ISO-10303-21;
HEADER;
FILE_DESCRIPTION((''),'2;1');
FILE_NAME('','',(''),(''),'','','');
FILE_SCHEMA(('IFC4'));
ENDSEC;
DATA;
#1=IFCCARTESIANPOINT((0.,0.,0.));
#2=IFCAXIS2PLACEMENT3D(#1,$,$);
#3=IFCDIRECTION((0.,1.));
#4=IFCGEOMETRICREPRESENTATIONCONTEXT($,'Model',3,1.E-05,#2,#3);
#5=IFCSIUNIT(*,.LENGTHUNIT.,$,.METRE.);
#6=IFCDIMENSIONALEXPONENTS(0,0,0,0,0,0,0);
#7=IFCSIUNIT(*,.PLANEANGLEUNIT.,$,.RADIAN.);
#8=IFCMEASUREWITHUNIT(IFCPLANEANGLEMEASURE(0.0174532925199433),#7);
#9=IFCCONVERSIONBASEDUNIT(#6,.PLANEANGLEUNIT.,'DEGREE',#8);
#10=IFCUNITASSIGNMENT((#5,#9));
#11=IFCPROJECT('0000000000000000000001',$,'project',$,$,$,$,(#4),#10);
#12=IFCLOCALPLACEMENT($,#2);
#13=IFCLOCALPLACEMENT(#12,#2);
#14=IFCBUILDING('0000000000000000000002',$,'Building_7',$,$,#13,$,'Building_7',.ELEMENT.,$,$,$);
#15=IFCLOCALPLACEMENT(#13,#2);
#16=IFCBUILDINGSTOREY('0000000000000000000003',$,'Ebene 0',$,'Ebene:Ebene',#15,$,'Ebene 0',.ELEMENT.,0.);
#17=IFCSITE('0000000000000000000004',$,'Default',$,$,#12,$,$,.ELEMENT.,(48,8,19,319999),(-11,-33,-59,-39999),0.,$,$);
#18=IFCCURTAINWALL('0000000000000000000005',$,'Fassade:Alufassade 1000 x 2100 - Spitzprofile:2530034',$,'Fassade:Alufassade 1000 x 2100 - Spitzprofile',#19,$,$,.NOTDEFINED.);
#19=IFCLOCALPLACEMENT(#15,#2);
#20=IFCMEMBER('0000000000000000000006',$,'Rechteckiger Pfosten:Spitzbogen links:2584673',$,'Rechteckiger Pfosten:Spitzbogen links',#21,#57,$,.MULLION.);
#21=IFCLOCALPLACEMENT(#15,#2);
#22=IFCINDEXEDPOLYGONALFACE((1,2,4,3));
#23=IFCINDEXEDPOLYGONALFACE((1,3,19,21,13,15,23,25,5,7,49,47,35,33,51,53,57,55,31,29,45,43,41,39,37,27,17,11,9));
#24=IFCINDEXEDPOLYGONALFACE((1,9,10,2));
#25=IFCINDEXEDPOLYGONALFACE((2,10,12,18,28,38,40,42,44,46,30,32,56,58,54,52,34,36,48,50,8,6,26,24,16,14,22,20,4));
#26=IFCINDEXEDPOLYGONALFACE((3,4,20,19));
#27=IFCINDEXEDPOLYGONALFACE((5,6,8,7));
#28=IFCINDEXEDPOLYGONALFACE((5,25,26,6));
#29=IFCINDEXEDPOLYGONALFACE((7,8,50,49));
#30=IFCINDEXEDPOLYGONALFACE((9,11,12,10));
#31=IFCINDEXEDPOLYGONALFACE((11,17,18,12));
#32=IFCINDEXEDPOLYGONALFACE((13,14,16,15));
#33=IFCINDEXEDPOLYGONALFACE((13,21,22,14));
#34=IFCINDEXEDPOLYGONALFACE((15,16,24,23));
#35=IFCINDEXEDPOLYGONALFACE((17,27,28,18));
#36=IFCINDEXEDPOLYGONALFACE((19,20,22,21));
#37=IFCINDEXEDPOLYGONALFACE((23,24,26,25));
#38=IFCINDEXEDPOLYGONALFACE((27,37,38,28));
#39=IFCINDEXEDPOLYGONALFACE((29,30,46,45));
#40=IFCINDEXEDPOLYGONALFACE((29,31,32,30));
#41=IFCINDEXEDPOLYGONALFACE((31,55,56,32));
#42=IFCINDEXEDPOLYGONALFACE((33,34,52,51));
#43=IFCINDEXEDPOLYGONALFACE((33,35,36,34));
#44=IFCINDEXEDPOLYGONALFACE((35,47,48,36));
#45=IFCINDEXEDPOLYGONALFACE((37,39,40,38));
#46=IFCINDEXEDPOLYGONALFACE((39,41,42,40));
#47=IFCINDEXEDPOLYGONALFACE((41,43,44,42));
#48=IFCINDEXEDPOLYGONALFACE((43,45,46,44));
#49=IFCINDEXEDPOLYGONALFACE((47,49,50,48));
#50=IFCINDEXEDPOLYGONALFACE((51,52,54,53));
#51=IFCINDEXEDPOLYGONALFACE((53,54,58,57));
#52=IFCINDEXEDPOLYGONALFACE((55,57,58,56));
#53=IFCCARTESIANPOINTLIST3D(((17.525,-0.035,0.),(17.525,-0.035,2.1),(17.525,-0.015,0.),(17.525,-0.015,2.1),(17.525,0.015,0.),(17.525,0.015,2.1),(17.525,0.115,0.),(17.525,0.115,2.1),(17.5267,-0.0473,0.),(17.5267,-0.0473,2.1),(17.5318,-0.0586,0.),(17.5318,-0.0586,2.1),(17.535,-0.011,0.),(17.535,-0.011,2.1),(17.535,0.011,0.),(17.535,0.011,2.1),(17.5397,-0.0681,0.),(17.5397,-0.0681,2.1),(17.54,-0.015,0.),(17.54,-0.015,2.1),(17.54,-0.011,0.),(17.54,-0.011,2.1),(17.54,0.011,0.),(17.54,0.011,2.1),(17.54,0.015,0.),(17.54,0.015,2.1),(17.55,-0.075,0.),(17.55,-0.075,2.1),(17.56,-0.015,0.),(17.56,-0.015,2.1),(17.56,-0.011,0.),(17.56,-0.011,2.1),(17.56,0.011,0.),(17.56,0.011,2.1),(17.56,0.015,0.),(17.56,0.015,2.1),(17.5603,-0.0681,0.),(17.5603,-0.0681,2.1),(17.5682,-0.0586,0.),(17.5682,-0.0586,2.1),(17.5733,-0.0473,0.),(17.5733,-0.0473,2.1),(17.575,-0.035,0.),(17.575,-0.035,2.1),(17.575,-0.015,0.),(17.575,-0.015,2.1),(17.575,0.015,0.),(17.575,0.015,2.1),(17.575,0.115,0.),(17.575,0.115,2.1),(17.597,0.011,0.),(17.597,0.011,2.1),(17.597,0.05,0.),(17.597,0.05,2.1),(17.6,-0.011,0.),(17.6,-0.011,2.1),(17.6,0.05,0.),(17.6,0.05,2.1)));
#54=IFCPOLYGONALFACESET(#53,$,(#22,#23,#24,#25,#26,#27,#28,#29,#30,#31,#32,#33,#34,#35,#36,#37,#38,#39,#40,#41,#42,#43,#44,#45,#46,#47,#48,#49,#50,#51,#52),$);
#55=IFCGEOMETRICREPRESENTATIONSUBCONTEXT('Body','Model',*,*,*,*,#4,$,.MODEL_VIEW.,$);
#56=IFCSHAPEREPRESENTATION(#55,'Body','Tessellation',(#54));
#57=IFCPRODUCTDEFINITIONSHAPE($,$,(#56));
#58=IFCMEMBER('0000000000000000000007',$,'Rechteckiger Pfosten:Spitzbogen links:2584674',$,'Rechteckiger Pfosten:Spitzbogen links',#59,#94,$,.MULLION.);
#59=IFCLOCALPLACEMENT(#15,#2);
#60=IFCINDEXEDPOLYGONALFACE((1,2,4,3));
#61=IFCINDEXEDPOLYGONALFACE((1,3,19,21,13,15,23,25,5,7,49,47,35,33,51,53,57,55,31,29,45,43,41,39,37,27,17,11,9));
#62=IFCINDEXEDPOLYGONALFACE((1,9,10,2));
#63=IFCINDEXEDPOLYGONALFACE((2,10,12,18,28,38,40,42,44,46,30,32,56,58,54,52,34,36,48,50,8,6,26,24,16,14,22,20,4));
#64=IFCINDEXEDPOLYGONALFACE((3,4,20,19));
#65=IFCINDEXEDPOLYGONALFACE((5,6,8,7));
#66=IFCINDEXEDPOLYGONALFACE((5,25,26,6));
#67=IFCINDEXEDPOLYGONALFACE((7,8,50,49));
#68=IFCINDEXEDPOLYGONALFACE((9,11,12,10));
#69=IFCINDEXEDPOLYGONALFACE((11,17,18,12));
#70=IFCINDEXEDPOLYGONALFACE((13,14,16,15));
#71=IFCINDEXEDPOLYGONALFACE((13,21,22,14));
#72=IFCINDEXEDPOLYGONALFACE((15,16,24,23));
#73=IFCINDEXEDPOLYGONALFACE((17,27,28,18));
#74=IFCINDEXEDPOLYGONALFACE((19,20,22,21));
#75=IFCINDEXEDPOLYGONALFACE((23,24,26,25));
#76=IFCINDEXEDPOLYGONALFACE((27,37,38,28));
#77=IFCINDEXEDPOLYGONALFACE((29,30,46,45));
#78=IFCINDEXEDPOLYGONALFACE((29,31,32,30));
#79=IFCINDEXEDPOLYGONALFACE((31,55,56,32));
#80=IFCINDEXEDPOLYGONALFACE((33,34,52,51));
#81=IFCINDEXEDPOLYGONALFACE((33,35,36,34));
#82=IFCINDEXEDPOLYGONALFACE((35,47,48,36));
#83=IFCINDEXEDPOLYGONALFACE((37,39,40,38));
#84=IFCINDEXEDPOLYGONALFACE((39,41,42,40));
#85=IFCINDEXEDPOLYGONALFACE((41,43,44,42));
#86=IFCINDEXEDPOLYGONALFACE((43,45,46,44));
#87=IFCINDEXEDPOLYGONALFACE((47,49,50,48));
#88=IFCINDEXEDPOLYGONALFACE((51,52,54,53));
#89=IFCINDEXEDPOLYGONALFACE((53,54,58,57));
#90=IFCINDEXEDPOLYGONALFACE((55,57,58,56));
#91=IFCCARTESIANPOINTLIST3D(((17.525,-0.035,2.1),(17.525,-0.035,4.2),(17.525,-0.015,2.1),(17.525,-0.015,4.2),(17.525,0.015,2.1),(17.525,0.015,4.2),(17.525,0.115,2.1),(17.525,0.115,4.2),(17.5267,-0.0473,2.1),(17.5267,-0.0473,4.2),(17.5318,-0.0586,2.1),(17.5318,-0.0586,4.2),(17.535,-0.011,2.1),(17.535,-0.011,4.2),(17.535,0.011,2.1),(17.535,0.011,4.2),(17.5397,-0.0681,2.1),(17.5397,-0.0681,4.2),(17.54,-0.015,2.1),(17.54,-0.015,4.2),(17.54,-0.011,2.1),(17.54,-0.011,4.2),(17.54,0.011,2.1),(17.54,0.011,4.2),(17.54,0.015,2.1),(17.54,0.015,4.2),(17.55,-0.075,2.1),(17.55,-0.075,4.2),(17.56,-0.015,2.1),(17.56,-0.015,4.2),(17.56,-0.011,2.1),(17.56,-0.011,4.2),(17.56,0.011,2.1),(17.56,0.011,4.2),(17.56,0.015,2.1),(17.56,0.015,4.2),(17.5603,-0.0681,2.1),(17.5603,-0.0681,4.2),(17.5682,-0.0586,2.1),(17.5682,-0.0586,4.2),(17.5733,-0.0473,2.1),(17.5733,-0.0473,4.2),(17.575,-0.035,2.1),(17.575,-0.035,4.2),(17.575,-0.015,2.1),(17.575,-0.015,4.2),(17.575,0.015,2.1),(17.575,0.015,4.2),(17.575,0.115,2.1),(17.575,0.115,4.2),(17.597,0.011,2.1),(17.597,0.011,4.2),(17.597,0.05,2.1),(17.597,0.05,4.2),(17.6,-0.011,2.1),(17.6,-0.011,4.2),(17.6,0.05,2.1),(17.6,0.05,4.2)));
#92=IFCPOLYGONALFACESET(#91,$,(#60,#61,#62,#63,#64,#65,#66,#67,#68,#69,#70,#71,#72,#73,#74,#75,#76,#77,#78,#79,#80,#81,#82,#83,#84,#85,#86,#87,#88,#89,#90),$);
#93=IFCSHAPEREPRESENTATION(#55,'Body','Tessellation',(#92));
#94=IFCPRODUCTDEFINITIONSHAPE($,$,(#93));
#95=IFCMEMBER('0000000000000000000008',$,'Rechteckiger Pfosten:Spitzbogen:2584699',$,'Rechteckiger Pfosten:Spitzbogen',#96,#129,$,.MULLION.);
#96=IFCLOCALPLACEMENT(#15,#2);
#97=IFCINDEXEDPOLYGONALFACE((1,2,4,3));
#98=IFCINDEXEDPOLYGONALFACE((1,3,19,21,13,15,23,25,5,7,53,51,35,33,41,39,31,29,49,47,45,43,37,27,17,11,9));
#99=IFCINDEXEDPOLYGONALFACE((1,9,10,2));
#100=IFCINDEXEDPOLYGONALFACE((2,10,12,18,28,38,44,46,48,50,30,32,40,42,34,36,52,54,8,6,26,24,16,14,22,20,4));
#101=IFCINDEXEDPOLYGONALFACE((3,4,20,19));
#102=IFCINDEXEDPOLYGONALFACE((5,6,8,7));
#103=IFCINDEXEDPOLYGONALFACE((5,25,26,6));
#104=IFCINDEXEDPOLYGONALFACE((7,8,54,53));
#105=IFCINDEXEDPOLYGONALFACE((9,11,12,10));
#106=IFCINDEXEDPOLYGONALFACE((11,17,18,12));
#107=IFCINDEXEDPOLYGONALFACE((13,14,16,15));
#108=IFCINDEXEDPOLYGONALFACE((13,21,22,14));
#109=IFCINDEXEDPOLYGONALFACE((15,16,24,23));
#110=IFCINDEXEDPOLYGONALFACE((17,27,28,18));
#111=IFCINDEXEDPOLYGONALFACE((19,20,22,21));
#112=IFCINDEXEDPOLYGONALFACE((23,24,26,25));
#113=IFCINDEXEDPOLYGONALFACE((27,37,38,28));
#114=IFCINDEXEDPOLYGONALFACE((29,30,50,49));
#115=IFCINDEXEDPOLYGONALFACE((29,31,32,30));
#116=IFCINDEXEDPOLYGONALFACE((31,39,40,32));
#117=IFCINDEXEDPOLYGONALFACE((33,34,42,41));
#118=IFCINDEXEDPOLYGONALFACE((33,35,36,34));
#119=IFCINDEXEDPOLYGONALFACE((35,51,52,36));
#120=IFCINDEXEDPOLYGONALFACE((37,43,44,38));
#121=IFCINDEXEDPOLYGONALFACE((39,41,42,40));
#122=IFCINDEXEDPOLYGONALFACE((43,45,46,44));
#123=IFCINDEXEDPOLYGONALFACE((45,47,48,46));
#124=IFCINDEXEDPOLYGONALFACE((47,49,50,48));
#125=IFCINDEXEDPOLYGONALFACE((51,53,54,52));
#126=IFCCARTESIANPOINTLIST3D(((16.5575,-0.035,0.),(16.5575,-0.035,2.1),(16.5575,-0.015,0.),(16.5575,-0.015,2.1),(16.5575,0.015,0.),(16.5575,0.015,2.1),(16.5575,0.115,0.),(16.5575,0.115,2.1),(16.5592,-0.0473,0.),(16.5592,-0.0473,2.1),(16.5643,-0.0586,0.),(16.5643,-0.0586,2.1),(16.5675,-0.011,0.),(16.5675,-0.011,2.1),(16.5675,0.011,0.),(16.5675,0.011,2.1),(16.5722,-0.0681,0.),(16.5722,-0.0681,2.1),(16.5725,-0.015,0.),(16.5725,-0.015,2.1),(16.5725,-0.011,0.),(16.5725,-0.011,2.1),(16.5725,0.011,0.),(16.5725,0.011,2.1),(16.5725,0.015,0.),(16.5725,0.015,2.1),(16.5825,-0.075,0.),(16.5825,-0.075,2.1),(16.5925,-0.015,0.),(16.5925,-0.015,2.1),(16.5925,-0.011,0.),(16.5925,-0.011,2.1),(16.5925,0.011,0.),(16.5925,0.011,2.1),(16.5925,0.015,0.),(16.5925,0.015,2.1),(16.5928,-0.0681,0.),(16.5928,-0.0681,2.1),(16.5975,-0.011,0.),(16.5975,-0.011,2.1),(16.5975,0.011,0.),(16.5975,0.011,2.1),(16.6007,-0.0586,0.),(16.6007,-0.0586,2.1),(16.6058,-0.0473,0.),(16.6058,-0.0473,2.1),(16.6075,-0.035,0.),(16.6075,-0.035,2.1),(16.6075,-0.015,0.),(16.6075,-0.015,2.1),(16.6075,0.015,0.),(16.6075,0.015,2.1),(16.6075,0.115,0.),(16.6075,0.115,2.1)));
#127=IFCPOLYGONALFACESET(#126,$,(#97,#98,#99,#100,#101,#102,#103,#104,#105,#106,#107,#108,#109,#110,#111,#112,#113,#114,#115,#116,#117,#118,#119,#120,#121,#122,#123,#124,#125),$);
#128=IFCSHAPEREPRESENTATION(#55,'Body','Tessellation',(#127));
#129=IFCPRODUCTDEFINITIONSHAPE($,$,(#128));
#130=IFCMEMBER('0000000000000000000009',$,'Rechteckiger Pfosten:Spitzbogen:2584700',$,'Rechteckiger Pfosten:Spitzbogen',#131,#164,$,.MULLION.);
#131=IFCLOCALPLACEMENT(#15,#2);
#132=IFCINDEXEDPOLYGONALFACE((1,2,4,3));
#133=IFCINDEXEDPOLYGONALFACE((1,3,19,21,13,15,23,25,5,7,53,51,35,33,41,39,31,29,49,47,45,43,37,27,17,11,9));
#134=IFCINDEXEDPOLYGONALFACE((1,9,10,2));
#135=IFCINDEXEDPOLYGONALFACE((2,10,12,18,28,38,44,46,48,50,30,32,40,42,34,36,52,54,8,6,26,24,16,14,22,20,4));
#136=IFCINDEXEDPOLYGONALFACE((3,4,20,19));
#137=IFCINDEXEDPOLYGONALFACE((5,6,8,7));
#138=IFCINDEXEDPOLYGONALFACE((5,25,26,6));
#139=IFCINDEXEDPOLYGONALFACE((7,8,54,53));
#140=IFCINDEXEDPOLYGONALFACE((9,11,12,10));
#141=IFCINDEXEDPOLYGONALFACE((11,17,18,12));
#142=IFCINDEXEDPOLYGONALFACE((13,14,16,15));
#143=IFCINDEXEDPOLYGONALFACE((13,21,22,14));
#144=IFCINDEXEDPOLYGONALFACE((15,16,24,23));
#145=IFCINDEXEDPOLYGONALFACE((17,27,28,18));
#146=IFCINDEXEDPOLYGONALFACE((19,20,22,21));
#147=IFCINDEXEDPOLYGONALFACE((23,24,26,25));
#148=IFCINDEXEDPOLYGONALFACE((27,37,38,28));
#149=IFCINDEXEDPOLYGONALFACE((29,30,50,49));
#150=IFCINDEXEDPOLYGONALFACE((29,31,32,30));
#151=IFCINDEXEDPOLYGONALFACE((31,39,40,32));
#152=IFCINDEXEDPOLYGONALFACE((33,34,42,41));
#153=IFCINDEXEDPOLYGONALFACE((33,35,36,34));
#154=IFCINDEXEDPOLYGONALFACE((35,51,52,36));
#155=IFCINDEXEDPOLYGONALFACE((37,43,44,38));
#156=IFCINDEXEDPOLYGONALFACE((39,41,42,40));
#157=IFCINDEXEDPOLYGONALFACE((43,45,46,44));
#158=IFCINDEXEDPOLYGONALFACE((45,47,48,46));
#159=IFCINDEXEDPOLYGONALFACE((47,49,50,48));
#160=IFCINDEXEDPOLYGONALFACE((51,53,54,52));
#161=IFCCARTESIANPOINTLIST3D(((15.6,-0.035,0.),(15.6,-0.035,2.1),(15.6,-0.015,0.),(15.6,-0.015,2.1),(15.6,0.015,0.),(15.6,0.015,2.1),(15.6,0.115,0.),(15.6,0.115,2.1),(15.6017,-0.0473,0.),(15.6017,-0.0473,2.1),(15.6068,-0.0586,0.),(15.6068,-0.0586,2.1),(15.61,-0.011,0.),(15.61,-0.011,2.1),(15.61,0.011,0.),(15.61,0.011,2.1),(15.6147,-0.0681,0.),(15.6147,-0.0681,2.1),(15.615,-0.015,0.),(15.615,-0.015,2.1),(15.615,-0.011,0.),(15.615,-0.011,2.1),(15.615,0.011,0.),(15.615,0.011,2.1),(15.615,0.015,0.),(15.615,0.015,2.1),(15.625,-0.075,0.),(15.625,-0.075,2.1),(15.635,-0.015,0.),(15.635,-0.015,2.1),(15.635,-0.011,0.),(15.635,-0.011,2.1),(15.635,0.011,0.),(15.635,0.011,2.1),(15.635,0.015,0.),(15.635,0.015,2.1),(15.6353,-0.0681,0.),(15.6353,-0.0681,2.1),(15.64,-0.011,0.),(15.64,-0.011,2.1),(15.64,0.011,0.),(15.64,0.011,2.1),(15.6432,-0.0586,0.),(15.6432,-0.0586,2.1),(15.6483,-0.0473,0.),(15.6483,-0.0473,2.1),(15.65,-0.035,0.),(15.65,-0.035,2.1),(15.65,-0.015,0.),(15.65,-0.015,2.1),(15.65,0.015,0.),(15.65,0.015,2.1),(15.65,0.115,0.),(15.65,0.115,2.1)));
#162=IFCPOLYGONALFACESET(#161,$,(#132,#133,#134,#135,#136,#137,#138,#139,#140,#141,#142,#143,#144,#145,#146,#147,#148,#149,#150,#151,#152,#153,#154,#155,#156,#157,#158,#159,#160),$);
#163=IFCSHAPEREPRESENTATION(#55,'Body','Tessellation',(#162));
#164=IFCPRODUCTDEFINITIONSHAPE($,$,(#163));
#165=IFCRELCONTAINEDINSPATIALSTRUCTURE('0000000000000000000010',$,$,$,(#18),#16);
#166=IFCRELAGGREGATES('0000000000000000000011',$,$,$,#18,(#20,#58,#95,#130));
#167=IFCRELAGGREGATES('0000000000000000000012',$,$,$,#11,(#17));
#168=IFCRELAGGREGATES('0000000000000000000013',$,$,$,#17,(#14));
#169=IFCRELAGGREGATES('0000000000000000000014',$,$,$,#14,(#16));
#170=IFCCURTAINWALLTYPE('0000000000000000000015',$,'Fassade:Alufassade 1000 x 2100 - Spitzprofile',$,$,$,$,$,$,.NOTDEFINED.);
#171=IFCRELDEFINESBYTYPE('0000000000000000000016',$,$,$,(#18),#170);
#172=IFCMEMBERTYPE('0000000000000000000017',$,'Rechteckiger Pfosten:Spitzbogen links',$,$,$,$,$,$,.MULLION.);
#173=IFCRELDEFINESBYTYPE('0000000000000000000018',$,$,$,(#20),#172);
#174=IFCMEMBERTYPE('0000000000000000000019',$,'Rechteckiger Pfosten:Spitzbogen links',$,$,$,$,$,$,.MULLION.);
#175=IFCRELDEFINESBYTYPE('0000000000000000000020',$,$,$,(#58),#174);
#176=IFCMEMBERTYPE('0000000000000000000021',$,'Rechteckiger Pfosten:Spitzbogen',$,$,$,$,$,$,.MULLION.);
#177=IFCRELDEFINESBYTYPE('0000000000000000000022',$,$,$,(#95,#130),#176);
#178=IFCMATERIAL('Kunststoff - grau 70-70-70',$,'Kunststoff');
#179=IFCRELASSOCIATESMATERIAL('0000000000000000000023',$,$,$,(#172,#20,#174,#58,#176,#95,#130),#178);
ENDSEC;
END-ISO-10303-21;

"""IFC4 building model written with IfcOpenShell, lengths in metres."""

from ifc_helpers import new_model, entity, si_unit, converted_unit, direction, frame, origin, place, context, subcontext, project, spatial, line, arc, indexed_curve, outline, extrude, source, transform, mapped, material, type_object, type_shapes, element, aggregate, save


model = new_model("IFC4")

# Units and contexts
model_context = context("Model", 3, precision=1e-05, world=origin(), true_north=direction((0.0, 1.0)))
body_context = subcontext(model_context, "Body", "Model", "MODEL_VIEW")
ifc_project = project(units=[si_unit("LENGTHUNIT", "METRE"), converted_unit("PLANEANGLEUNIT", "DEGREE", entity("IfcPlaneAngleMeasure", 0.0174532925199433), si_unit("PLANEANGLEUNIT", "RADIAN"), dimensions=[0, 0, 0, 0, 0, 0, 0])], contexts=[model_context])

# Site, building, storey
site_placement = place(None, origin())
site = spatial("IfcSite", under=ifc_project, at=site_placement, Name="Default", CompositionType="ELEMENT", RefLatitude=(48, 8, 19, 319999), RefLongitude=(-11, -33, -59, -39999), RefElevation=0.0)
building_placement = place(site_placement, origin())
building = spatial("IfcBuilding", under=site, at=building_placement, Name="Building_7", LongName="Building_7", CompositionType="ELEMENT")
storey_placement = place(building_placement, origin())
storey = spatial("IfcBuildingStorey", under=building, at=storey_placement, Name="Ebene 0", ObjectType="Ebene:Ebene", LongName="Ebene 0", CompositionType="ELEMENT", Elevation=0.0)

# Curtain wall, members
curtain_wall_type = type_object("IfcCurtainWallType", Name="Fassade:Alufassade 1000 x 2100 - Spitzprofile", PredefinedType="NOTDEFINED")
curtain_wall_placement = place(storey_placement, origin())
curtain_wall = element("IfcCurtainWall", 1, at=curtain_wall_placement, inside=storey, type_object=curtain_wall_type, Name="Fassade:Alufassade 1000 x 2100 - Spitzprofile:2530034", ObjectType="Fassade:Alufassade 1000 x 2100 - Spitzprofile", PredefinedType="NOTDEFINED")
ifc_material = material(Name="Kunststoff - grau 70-70-70", Category="Kunststoff")
member_type_1 = type_object("IfcMemberType", Name="Rechteckiger Pfosten:Spitzbogen links", PredefinedType="MULLION", material=ifc_material)
shared_shape_1 = source(origin(), body_context, "Body", "SweptSolid", [
    extrude(outline(indexed_curve([(-0.107, -0.0321), (-0.007, -0.0321), (-0.007, -0.0171), (-0.003, -0.0171), (-0.003, -0.0221), (0.019, -0.0221), (0.019, -0.0171), (0.023, -0.0171), (0.023, -0.0321), (0.043, -0.0321), (0.0666, -0.0254), (0.083, -0.0071), (0.0666, 0.0111), (0.043, 0.0179), (0.023, 0.0179), (0.023, 0.0029), (0.019, 0.0029), (0.019, 0.0429), (-0.042, 0.0429), (-0.042, 0.0399), (-0.003, 0.0399), (-0.003, 0.0029), (-0.007, 0.0029), (-0.007, 0.0179), (-0.107, 0.0179)], segments=[line(1, 2, 3, 4, 5, 6, 7, 8, 9, 10), arc(10, 11, 12), arc(12, 13, 14), line(14, 15, 16, 17, 18, 19, 20, 21, 22, 23, 24, 25, 1)], self_intersect=False)), frame((-0.0429, 0.008, -2.1), z_axis=(0.0, 0.0, 1.0), x_axis=(0.0, -1.0, 0.0)), (0.0, 0.0, 1.0), 2.1),
])
type_shapes(member_type_1, [shared_shape_1])
member_1_placement = place(curtain_wall_placement, frame((17.6, 0.0, 2.1)))
member_1 = element("IfcMember", 2, at=member_1_placement, type_object=member_type_1, material=ifc_material, Name="Rechteckiger Pfosten:Spitzbogen links:2584673", ObjectType="Rechteckiger Pfosten:Spitzbogen links", PredefinedType="MULLION", context=body_context, shape_type="MappedRepresentation", body=[
    mapped(shared_shape_1, transform((0.0, 0.0, 0.0), scale=1.0)),
])
member_type_2 = type_object("IfcMemberType", Name="Rechteckiger Pfosten:Spitzbogen links", PredefinedType="MULLION", material=ifc_material)
shared_shape_2 = source(origin(), body_context, "Body", "SweptSolid", [
    extrude(outline(indexed_curve([(-0.107, -0.0321), (-0.007, -0.0321), (-0.007, -0.0171), (-0.003, -0.0171), (-0.003, -0.0221), (0.019, -0.0221), (0.019, -0.0171), (0.023, -0.0171), (0.023, -0.0321), (0.043, -0.0321), (0.0666, -0.0254), (0.083, -0.0071), (0.0666, 0.0111), (0.043, 0.0179), (0.023, 0.0179), (0.023, 0.0029), (0.019, 0.0029), (0.019, 0.0429), (-0.042, 0.0429), (-0.042, 0.0399), (-0.003, 0.0399), (-0.003, 0.0029), (-0.007, 0.0029), (-0.007, 0.0179), (-0.107, 0.0179)], segments=[line(1, 2, 3, 4, 5, 6, 7, 8, 9, 10), arc(10, 11, 12), arc(12, 13, 14), line(14, 15, 16, 17, 18, 19, 20, 21, 22, 23, 24, 25, 1)], self_intersect=False)), frame((-0.0429, 0.008, -2.1), z_axis=(0.0, 0.0, 1.0), x_axis=(0.0, -1.0, 0.0)), (0.0, 0.0, 1.0), 2.1),
])
type_shapes(member_type_2, [shared_shape_2])
member_2_placement = place(curtain_wall_placement, frame((17.6, 0.0, 4.2)))
member_2 = element("IfcMember", 3, at=member_2_placement, type_object=member_type_2, material=ifc_material, Name="Rechteckiger Pfosten:Spitzbogen links:2584674", ObjectType="Rechteckiger Pfosten:Spitzbogen links", PredefinedType="MULLION", context=body_context, shape_type="MappedRepresentation", body=[
    mapped(shared_shape_2, transform((0.0, 0.0, 0.0), scale=1.0)),
])
member_type_3 = type_object("IfcMemberType", Name="Rechteckiger Pfosten:Spitzbogen", PredefinedType="MULLION", material=ifc_material)
shared_shape_3 = source(origin(), body_context, "Body", "SweptSolid", [
    extrude(outline(indexed_curve([(-0.111, -0.025), (-0.011, -0.025), (-0.011, -0.01), (-0.007, -0.01), (-0.007, -0.015), (0.015, -0.015), (0.015, -0.01), (0.019, -0.01), (0.019, -0.025), (0.039, -0.025), (0.0626, -0.0182), (0.079, 0.0), (0.0626, 0.0182), (0.039, 0.025), (0.019, 0.025), (0.019, 0.01), (0.015, 0.01), (0.015, 0.015), (-0.007, 0.015), (-0.007, 0.01), (-0.011, 0.01), (-0.011, 0.025), (-0.111, 0.025)], segments=[line(1, 2, 3, 4, 5, 6, 7, 8, 9, 10), arc(10, 11, 12), arc(12, 13, 14), line(14, 15, 16, 17, 18, 19, 20, 21, 22, 23, 1)], self_intersect=False)), frame((0.0, 0.004, -2.1), z_axis=(0.0, 0.0, 1.0), x_axis=(0.0, -1.0, 0.0)), (0.0, 0.0, 1.0), 2.1),
])
type_shapes(member_type_3, [shared_shape_3])
member_3_placement = place(curtain_wall_placement, frame((16.5825, 0.0, 0.0), z_axis=(0.0, 0.0, -1.0), x_axis=(-1.0, 0.0, 0.0)))
member_3 = element("IfcMember", 4, at=member_3_placement, type_object=member_type_3, material=ifc_material, Name="Rechteckiger Pfosten:Spitzbogen:2584699", ObjectType="Rechteckiger Pfosten:Spitzbogen", PredefinedType="MULLION", context=body_context, shape_type="MappedRepresentation", body=[
    mapped(shared_shape_3, transform((0.0, 0.0, 0.0), scale=1.0)),
])
member_4_placement = place(curtain_wall_placement, frame((15.625, 0.0, 0.0), z_axis=(0.0, 0.0, -1.0), x_axis=(-1.0, 0.0, 0.0)))
member_4 = element("IfcMember", 5, at=member_4_placement, type_object=member_type_3, material=ifc_material, Name="Rechteckiger Pfosten:Spitzbogen:2584700", ObjectType="Rechteckiger Pfosten:Spitzbogen", PredefinedType="MULLION", context=body_context, shape_type="MappedRepresentation", body=[
    mapped(shared_shape_3, transform((0.0, 0.0, 0.0), scale=1.0)),
])
aggregate(curtain_wall, [member_1, member_2, member_3, member_4])

save(model, "model.ifc")
